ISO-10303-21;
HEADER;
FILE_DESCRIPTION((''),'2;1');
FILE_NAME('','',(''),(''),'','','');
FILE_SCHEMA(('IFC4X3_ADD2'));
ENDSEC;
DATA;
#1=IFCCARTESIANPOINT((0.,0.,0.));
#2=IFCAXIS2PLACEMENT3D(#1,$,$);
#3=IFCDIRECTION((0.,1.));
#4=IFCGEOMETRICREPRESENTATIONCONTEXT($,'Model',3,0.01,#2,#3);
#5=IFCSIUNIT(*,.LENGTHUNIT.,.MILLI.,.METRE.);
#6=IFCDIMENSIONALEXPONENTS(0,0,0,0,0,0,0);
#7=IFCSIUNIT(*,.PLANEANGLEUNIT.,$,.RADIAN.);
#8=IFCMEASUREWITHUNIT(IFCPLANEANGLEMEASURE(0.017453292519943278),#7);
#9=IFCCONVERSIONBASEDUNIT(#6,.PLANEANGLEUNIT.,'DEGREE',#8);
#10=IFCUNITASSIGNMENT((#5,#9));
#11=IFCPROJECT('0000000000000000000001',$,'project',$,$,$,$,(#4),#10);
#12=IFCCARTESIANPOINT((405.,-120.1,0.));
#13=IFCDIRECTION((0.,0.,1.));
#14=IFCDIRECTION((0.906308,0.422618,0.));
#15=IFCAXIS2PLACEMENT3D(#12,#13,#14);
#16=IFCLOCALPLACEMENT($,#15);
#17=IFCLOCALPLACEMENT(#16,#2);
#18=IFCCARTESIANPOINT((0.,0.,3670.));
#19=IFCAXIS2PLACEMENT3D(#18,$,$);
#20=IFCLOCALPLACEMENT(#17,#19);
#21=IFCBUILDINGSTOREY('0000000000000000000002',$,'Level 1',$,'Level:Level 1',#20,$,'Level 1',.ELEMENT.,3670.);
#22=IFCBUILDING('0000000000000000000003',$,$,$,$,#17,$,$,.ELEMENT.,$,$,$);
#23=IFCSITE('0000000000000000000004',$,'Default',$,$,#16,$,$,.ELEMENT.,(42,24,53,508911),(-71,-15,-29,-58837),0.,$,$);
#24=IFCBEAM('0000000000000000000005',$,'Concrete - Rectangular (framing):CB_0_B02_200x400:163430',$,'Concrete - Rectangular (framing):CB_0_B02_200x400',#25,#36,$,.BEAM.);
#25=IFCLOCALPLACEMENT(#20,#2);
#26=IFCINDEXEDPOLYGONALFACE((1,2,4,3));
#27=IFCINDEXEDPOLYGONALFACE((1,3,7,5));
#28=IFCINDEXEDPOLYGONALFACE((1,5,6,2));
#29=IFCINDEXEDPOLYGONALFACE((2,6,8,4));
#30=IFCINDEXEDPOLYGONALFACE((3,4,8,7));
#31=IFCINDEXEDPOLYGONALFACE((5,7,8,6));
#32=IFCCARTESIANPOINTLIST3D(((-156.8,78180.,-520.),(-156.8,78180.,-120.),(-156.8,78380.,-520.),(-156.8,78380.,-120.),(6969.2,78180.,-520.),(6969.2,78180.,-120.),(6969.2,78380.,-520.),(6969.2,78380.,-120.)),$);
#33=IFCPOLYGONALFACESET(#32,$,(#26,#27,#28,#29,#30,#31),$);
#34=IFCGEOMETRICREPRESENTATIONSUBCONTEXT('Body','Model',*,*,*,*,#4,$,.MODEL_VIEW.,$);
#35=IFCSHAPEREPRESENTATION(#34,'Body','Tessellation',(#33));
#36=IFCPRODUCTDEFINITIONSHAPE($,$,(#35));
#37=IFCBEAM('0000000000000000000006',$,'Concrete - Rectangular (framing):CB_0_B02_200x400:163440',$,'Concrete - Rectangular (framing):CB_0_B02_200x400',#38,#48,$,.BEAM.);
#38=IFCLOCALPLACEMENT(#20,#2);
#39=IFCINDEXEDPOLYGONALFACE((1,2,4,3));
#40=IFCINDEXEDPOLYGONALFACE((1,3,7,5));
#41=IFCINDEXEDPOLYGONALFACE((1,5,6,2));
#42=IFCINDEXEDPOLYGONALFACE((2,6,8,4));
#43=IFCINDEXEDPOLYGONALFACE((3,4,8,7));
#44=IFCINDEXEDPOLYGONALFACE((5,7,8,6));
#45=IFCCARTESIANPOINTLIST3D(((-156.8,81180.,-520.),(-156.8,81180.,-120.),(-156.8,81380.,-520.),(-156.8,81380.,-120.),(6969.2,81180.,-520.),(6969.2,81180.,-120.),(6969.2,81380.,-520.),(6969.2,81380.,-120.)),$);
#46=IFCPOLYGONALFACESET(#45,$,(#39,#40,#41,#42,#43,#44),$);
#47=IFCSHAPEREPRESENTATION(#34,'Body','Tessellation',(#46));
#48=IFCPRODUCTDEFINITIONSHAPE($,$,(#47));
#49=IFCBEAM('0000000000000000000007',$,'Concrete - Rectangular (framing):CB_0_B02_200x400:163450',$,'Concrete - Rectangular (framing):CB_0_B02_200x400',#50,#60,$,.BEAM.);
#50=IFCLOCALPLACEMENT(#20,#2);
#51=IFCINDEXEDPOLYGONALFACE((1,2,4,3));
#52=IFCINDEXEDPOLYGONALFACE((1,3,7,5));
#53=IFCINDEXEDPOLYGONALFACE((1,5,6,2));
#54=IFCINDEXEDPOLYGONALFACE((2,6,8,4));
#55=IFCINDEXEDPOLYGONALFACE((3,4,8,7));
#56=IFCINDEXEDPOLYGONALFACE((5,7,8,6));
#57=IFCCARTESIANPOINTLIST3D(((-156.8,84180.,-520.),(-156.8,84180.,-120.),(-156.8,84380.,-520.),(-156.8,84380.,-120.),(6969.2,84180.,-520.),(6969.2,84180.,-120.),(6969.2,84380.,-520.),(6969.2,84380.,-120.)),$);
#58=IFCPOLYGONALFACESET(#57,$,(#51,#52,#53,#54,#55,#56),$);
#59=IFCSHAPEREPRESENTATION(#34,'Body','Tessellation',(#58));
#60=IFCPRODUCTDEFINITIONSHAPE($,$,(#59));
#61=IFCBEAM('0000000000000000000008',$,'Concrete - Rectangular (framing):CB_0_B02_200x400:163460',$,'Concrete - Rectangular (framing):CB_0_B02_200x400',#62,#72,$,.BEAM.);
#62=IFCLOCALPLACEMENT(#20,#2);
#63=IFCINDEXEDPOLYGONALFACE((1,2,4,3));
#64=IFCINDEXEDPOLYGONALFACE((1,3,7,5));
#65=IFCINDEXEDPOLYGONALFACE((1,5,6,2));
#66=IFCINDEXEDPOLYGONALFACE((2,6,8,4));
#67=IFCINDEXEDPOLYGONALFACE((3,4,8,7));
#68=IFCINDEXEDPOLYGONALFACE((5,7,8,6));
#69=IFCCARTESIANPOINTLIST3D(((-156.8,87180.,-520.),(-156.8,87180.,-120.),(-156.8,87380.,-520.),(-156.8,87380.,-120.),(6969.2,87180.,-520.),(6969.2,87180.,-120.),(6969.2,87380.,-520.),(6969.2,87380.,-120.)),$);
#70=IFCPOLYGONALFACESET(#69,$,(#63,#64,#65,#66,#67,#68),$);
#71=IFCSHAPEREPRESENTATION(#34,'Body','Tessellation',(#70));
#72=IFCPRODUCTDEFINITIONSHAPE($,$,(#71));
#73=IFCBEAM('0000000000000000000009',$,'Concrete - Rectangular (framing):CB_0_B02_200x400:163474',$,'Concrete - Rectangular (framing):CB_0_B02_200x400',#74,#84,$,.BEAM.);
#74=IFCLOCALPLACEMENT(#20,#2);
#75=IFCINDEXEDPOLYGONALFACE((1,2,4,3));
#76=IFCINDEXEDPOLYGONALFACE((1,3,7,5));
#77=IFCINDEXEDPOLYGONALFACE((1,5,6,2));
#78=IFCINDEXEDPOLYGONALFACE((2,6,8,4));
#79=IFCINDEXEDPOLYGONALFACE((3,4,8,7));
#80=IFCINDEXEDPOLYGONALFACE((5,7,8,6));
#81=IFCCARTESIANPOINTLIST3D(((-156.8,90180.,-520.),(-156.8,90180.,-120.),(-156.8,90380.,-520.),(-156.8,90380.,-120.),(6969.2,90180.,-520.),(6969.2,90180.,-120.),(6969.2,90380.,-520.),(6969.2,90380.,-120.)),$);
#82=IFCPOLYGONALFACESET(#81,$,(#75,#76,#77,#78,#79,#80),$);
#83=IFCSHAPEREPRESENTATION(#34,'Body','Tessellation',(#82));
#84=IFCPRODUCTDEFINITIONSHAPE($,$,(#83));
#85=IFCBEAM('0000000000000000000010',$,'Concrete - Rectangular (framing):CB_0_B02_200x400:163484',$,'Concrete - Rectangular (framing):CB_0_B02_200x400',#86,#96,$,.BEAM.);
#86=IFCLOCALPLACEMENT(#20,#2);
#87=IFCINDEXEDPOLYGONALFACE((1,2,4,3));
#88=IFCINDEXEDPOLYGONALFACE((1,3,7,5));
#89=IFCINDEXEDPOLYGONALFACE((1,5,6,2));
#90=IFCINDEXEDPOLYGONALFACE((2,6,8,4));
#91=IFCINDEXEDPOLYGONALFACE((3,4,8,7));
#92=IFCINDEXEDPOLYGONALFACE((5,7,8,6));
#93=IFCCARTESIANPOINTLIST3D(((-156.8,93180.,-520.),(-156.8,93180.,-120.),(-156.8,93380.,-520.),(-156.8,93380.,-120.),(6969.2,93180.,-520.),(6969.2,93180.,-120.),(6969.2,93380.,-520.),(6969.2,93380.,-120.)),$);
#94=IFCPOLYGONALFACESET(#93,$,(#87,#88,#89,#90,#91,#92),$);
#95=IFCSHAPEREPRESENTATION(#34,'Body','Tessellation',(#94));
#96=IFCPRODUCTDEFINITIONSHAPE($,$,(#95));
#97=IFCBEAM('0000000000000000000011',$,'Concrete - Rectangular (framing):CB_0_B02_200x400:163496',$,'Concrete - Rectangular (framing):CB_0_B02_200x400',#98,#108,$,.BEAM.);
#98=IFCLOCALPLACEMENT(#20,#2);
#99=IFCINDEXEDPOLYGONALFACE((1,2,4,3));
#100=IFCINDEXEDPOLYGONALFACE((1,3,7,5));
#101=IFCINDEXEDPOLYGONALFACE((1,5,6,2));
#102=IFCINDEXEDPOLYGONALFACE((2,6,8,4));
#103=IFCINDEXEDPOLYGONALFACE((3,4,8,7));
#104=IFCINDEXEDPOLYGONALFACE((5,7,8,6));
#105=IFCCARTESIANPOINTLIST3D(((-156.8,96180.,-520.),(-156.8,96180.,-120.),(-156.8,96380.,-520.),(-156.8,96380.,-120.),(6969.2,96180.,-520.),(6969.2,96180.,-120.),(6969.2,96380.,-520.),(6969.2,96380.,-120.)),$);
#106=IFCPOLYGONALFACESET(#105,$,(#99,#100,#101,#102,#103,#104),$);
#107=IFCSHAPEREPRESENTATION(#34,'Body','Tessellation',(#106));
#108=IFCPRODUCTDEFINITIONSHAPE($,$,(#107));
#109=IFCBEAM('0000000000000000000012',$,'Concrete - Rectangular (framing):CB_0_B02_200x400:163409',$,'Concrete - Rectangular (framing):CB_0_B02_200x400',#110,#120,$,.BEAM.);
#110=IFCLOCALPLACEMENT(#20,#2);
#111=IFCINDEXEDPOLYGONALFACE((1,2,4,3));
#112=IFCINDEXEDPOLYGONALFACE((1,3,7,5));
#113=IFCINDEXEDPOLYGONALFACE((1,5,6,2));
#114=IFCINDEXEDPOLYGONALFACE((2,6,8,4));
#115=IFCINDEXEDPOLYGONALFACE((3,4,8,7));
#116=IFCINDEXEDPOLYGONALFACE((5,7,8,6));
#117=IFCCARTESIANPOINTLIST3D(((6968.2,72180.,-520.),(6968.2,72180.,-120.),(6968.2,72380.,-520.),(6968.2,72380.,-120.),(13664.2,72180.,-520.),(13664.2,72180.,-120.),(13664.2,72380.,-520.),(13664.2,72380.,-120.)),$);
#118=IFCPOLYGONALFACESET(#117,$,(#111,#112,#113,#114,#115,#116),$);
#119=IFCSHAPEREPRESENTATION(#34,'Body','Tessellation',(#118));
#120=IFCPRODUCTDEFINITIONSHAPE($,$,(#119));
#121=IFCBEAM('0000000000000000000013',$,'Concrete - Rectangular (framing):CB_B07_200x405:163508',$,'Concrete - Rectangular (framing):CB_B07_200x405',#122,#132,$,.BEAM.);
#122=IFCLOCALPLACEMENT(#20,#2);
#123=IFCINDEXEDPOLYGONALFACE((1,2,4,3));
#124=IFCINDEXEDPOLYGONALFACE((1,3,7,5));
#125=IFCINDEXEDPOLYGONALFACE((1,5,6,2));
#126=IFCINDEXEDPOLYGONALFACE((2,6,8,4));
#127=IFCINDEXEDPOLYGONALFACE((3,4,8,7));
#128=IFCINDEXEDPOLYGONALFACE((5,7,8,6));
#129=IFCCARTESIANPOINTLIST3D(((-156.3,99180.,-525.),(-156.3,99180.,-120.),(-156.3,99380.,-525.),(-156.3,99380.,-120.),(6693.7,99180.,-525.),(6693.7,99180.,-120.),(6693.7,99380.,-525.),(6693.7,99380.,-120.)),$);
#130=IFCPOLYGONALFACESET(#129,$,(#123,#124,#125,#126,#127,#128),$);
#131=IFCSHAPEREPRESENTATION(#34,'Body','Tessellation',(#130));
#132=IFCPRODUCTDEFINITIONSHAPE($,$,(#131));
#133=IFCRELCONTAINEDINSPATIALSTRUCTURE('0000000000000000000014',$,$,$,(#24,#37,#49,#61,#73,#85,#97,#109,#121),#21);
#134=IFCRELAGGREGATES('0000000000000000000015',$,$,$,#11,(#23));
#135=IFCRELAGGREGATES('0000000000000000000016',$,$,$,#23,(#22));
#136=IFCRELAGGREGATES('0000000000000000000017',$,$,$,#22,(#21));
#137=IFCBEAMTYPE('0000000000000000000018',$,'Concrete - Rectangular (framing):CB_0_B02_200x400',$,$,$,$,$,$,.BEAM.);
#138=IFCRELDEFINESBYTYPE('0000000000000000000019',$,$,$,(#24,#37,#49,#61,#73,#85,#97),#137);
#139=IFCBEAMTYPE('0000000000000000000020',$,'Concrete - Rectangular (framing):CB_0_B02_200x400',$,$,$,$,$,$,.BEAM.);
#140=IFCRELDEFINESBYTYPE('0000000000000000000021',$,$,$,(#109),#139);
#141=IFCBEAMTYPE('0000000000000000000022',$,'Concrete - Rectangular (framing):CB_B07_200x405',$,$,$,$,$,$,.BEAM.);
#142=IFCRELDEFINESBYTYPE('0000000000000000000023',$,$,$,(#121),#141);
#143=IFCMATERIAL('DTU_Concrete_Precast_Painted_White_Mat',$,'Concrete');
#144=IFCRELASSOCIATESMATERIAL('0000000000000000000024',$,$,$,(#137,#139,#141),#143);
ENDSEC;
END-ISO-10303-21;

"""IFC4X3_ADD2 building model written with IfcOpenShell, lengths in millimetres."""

from ifc_helpers import new_model, entity, si_unit, converted_unit, direction, frame, frame_2d, origin, origin_2d_with_axis, place, context, subcontext, project, spatial, rectangle, extrude, source, transform, mapped, material, material_profile, profile_set, type_object, type_shapes, element, save


model = new_model("IFC4X3_ADD2")

# Units and contexts
model_context = context("Model", 3, precision=0.01, world=origin(), true_north=direction((0.0, 1.0)))
body_context = subcontext(model_context, "Body", "Model", "MODEL_VIEW")
ifc_project = project(units=[si_unit("LENGTHUNIT", "METRE", prefix="MILLI"), converted_unit("PLANEANGLEUNIT", "DEGREE", entity("IfcPlaneAngleMeasure", 0.017453292519943278), si_unit("PLANEANGLEUNIT", "RADIAN"), dimensions=[0, 0, 0, 0, 0, 0, 0])], contexts=[model_context])

# Site, building, storey
site_placement = place(None, frame((405.0, -120.1, 0.0), z_axis=(0.0, 0.0, 1.0), x_axis=(0.906308, 0.422618, 0.0)))
site = spatial("IfcSite", under=ifc_project, at=site_placement, Name="Default", CompositionType="ELEMENT", RefLatitude=(42, 24, 53, 508911), RefLongitude=(-71, -15, -29, -58837), RefElevation=0.0)
building_placement = place(site_placement, origin())
building = spatial("IfcBuilding", under=site, at=building_placement, CompositionType="ELEMENT")
storey_placement = place(building_placement, frame((0.0, 0.0, 3670.0)))
storey = spatial("IfcBuildingStorey", under=building, at=storey_placement, Name="Level 1", ObjectType="Level:Level 1", LongName="Level 1", CompositionType="ELEMENT", Elevation=3670.0)

# Beams
ifc_material = material(Name="DTU_Concrete_Precast_Painted_White_Mat", Category="Concrete")
ifc_material_profile_1 = material_profile(ifc_material, rectangle(XDim=7035.5, YDim=200.0, at=frame_2d((0.0, 0.0), x_axis=(1.0, 0.0))), Name="CB_0_B02_200x400")
ifc_profile_set_1 = profile_set([ifc_material_profile_1], Name="CB_0_B02_200x400")
beam_type_1 = type_object("IfcBeamType", Name="Concrete - Rectangular (framing):CB_0_B02_200x400", PredefinedType="BEAM", material=ifc_profile_set_1)
shared_shape_1 = source(origin(), body_context, "Body", "SweptSolid", [
    extrude(rectangle(XDim=7126.0, YDim=200.0, at=origin_2d_with_axis()), frame((0.0, 0.0, -200.0), z_axis=(0.0, 0.0, 1.0), x_axis=(-1.0, 0.0, 0.0)), (0.0, 0.0, 1.0), 400.0),
])
type_shapes(beam_type_1, [shared_shape_1])
for number, where, z_axis, x_axis, name in (
    (1, (3406.2, 78280.0, -320.0), (0.0, 0.0, 1.0), (-1.0, 0.0, 0.0), "Concrete - Rectangular (framing):CB_0_B02_200x400:163430"),
    (2, (3406.2, 81280.0, -320.0), (0.0, 0.0, 1.0), (-1.0, 0.0, 0.0), "Concrete - Rectangular (framing):CB_0_B02_200x400:163440"),
    (3, (3406.2, 84280.0, -320.0), (0.0, 0.0, 1.0), (-1.0, 0.0, 0.0), "Concrete - Rectangular (framing):CB_0_B02_200x400:163450"),
    (4, (3406.2, 87280.0, -320.0), (0.0, 0.0, 1.0), (-1.0, 0.0, 0.0), "Concrete - Rectangular (framing):CB_0_B02_200x400:163460"),
    (5, (3406.2, 90280.0, -320.0), (0.0, 0.0, 1.0), (-1.0, 0.0, 0.0), "Concrete - Rectangular (framing):CB_0_B02_200x400:163474"),
    (6, (3406.2, 93280.0, -320.0), (0.0, 0.0, 1.0), (-1.0, 0.0, 0.0), "Concrete - Rectangular (framing):CB_0_B02_200x400:163484"),
    (7, (3406.2, 96280.0, -320.0), (0.0, 0.0, 1.0), (-1.0, 0.0, 0.0), "Concrete - Rectangular (framing):CB_0_B02_200x400:163496"),
):
    element("IfcBeam", number, at=place(storey_placement, frame(where, z_axis=z_axis, x_axis=x_axis)), inside=storey, type_object=beam_type_1, Name=name, ObjectType="Concrete - Rectangular (framing):CB_0_B02_200x400", PredefinedType="BEAM", context=body_context, shape_type="MappedRepresentation", body=[
        mapped(shared_shape_1, transform((0.0, 0.0, 0.0), scale=1.0)),
    ])
beam_type_2 = type_object("IfcBeamType", Name="Concrete - Rectangular (framing):CB_0_B02_200x400", PredefinedType="BEAM", material=ifc_profile_set_1)
shared_shape_2 = source(origin(), body_context, "Body", "SweptSolid", [
    extrude(rectangle(XDim=6696.0, YDim=200.0, at=origin_2d_with_axis()), frame((0.0, 0.0, -200.0), z_axis=(0.0, 0.0, 1.0), x_axis=(-1.0, 0.0, 0.0)), (0.0, 0.0, 1.0), 400.0),
])
type_shapes(beam_type_2, [shared_shape_2])
beam_1_placement = place(storey_placement, frame((10316.2, 72280.0, -320.0)))
element("IfcBeam", 8, at=beam_1_placement, inside=storey, type_object=beam_type_2, Name="Concrete - Rectangular (framing):CB_0_B02_200x400:163409", ObjectType="Concrete - Rectangular (framing):CB_0_B02_200x400", PredefinedType="BEAM", context=body_context, shape_type="MappedRepresentation", body=[
    mapped(shared_shape_2, transform((0.0, 0.0, 0.0), scale=1.0)),
])
ifc_material_profile_2 = material_profile(ifc_material, rectangle(XDim=6850.0, YDim=200.0, at=origin_2d_with_axis()), Name="CB_B07_200x405")
ifc_profile_set_2 = profile_set([ifc_material_profile_2], Name="CB_B07_200x405")
beam_type_3 = type_object("IfcBeamType", Name="Concrete - Rectangular (framing):CB_B07_200x405", PredefinedType="BEAM", material=ifc_profile_set_2)
shared_shape_3 = source(origin(), body_context, "Body", "SweptSolid", [
    extrude(rectangle(XDim=6850.0, YDim=200.0, at=origin_2d_with_axis()), frame((137.5, 0.0, -202.5), z_axis=(0.0, 0.0, 1.0), x_axis=(-1.0, 0.0, 0.0)), (0.0, 0.0, 1.0), 405.0),
])
type_shapes(beam_type_3, [shared_shape_3])
beam_2_placement = place(storey_placement, frame((3406.2, 99280.0, -322.5), z_axis=(0.0, 0.0, 1.0), x_axis=(-1.0, 0.0, 0.0)))
element("IfcBeam", 9, at=beam_2_placement, inside=storey, type_object=beam_type_3, Name="Concrete - Rectangular (framing):CB_B07_200x405:163508", ObjectType="Concrete - Rectangular (framing):CB_B07_200x405", PredefinedType="BEAM", context=body_context, shape_type="MappedRepresentation", body=[
    mapped(shared_shape_3, transform((0.0, 0.0, 0.0), scale=1.0)),
])

save(model, "model.ifc")
